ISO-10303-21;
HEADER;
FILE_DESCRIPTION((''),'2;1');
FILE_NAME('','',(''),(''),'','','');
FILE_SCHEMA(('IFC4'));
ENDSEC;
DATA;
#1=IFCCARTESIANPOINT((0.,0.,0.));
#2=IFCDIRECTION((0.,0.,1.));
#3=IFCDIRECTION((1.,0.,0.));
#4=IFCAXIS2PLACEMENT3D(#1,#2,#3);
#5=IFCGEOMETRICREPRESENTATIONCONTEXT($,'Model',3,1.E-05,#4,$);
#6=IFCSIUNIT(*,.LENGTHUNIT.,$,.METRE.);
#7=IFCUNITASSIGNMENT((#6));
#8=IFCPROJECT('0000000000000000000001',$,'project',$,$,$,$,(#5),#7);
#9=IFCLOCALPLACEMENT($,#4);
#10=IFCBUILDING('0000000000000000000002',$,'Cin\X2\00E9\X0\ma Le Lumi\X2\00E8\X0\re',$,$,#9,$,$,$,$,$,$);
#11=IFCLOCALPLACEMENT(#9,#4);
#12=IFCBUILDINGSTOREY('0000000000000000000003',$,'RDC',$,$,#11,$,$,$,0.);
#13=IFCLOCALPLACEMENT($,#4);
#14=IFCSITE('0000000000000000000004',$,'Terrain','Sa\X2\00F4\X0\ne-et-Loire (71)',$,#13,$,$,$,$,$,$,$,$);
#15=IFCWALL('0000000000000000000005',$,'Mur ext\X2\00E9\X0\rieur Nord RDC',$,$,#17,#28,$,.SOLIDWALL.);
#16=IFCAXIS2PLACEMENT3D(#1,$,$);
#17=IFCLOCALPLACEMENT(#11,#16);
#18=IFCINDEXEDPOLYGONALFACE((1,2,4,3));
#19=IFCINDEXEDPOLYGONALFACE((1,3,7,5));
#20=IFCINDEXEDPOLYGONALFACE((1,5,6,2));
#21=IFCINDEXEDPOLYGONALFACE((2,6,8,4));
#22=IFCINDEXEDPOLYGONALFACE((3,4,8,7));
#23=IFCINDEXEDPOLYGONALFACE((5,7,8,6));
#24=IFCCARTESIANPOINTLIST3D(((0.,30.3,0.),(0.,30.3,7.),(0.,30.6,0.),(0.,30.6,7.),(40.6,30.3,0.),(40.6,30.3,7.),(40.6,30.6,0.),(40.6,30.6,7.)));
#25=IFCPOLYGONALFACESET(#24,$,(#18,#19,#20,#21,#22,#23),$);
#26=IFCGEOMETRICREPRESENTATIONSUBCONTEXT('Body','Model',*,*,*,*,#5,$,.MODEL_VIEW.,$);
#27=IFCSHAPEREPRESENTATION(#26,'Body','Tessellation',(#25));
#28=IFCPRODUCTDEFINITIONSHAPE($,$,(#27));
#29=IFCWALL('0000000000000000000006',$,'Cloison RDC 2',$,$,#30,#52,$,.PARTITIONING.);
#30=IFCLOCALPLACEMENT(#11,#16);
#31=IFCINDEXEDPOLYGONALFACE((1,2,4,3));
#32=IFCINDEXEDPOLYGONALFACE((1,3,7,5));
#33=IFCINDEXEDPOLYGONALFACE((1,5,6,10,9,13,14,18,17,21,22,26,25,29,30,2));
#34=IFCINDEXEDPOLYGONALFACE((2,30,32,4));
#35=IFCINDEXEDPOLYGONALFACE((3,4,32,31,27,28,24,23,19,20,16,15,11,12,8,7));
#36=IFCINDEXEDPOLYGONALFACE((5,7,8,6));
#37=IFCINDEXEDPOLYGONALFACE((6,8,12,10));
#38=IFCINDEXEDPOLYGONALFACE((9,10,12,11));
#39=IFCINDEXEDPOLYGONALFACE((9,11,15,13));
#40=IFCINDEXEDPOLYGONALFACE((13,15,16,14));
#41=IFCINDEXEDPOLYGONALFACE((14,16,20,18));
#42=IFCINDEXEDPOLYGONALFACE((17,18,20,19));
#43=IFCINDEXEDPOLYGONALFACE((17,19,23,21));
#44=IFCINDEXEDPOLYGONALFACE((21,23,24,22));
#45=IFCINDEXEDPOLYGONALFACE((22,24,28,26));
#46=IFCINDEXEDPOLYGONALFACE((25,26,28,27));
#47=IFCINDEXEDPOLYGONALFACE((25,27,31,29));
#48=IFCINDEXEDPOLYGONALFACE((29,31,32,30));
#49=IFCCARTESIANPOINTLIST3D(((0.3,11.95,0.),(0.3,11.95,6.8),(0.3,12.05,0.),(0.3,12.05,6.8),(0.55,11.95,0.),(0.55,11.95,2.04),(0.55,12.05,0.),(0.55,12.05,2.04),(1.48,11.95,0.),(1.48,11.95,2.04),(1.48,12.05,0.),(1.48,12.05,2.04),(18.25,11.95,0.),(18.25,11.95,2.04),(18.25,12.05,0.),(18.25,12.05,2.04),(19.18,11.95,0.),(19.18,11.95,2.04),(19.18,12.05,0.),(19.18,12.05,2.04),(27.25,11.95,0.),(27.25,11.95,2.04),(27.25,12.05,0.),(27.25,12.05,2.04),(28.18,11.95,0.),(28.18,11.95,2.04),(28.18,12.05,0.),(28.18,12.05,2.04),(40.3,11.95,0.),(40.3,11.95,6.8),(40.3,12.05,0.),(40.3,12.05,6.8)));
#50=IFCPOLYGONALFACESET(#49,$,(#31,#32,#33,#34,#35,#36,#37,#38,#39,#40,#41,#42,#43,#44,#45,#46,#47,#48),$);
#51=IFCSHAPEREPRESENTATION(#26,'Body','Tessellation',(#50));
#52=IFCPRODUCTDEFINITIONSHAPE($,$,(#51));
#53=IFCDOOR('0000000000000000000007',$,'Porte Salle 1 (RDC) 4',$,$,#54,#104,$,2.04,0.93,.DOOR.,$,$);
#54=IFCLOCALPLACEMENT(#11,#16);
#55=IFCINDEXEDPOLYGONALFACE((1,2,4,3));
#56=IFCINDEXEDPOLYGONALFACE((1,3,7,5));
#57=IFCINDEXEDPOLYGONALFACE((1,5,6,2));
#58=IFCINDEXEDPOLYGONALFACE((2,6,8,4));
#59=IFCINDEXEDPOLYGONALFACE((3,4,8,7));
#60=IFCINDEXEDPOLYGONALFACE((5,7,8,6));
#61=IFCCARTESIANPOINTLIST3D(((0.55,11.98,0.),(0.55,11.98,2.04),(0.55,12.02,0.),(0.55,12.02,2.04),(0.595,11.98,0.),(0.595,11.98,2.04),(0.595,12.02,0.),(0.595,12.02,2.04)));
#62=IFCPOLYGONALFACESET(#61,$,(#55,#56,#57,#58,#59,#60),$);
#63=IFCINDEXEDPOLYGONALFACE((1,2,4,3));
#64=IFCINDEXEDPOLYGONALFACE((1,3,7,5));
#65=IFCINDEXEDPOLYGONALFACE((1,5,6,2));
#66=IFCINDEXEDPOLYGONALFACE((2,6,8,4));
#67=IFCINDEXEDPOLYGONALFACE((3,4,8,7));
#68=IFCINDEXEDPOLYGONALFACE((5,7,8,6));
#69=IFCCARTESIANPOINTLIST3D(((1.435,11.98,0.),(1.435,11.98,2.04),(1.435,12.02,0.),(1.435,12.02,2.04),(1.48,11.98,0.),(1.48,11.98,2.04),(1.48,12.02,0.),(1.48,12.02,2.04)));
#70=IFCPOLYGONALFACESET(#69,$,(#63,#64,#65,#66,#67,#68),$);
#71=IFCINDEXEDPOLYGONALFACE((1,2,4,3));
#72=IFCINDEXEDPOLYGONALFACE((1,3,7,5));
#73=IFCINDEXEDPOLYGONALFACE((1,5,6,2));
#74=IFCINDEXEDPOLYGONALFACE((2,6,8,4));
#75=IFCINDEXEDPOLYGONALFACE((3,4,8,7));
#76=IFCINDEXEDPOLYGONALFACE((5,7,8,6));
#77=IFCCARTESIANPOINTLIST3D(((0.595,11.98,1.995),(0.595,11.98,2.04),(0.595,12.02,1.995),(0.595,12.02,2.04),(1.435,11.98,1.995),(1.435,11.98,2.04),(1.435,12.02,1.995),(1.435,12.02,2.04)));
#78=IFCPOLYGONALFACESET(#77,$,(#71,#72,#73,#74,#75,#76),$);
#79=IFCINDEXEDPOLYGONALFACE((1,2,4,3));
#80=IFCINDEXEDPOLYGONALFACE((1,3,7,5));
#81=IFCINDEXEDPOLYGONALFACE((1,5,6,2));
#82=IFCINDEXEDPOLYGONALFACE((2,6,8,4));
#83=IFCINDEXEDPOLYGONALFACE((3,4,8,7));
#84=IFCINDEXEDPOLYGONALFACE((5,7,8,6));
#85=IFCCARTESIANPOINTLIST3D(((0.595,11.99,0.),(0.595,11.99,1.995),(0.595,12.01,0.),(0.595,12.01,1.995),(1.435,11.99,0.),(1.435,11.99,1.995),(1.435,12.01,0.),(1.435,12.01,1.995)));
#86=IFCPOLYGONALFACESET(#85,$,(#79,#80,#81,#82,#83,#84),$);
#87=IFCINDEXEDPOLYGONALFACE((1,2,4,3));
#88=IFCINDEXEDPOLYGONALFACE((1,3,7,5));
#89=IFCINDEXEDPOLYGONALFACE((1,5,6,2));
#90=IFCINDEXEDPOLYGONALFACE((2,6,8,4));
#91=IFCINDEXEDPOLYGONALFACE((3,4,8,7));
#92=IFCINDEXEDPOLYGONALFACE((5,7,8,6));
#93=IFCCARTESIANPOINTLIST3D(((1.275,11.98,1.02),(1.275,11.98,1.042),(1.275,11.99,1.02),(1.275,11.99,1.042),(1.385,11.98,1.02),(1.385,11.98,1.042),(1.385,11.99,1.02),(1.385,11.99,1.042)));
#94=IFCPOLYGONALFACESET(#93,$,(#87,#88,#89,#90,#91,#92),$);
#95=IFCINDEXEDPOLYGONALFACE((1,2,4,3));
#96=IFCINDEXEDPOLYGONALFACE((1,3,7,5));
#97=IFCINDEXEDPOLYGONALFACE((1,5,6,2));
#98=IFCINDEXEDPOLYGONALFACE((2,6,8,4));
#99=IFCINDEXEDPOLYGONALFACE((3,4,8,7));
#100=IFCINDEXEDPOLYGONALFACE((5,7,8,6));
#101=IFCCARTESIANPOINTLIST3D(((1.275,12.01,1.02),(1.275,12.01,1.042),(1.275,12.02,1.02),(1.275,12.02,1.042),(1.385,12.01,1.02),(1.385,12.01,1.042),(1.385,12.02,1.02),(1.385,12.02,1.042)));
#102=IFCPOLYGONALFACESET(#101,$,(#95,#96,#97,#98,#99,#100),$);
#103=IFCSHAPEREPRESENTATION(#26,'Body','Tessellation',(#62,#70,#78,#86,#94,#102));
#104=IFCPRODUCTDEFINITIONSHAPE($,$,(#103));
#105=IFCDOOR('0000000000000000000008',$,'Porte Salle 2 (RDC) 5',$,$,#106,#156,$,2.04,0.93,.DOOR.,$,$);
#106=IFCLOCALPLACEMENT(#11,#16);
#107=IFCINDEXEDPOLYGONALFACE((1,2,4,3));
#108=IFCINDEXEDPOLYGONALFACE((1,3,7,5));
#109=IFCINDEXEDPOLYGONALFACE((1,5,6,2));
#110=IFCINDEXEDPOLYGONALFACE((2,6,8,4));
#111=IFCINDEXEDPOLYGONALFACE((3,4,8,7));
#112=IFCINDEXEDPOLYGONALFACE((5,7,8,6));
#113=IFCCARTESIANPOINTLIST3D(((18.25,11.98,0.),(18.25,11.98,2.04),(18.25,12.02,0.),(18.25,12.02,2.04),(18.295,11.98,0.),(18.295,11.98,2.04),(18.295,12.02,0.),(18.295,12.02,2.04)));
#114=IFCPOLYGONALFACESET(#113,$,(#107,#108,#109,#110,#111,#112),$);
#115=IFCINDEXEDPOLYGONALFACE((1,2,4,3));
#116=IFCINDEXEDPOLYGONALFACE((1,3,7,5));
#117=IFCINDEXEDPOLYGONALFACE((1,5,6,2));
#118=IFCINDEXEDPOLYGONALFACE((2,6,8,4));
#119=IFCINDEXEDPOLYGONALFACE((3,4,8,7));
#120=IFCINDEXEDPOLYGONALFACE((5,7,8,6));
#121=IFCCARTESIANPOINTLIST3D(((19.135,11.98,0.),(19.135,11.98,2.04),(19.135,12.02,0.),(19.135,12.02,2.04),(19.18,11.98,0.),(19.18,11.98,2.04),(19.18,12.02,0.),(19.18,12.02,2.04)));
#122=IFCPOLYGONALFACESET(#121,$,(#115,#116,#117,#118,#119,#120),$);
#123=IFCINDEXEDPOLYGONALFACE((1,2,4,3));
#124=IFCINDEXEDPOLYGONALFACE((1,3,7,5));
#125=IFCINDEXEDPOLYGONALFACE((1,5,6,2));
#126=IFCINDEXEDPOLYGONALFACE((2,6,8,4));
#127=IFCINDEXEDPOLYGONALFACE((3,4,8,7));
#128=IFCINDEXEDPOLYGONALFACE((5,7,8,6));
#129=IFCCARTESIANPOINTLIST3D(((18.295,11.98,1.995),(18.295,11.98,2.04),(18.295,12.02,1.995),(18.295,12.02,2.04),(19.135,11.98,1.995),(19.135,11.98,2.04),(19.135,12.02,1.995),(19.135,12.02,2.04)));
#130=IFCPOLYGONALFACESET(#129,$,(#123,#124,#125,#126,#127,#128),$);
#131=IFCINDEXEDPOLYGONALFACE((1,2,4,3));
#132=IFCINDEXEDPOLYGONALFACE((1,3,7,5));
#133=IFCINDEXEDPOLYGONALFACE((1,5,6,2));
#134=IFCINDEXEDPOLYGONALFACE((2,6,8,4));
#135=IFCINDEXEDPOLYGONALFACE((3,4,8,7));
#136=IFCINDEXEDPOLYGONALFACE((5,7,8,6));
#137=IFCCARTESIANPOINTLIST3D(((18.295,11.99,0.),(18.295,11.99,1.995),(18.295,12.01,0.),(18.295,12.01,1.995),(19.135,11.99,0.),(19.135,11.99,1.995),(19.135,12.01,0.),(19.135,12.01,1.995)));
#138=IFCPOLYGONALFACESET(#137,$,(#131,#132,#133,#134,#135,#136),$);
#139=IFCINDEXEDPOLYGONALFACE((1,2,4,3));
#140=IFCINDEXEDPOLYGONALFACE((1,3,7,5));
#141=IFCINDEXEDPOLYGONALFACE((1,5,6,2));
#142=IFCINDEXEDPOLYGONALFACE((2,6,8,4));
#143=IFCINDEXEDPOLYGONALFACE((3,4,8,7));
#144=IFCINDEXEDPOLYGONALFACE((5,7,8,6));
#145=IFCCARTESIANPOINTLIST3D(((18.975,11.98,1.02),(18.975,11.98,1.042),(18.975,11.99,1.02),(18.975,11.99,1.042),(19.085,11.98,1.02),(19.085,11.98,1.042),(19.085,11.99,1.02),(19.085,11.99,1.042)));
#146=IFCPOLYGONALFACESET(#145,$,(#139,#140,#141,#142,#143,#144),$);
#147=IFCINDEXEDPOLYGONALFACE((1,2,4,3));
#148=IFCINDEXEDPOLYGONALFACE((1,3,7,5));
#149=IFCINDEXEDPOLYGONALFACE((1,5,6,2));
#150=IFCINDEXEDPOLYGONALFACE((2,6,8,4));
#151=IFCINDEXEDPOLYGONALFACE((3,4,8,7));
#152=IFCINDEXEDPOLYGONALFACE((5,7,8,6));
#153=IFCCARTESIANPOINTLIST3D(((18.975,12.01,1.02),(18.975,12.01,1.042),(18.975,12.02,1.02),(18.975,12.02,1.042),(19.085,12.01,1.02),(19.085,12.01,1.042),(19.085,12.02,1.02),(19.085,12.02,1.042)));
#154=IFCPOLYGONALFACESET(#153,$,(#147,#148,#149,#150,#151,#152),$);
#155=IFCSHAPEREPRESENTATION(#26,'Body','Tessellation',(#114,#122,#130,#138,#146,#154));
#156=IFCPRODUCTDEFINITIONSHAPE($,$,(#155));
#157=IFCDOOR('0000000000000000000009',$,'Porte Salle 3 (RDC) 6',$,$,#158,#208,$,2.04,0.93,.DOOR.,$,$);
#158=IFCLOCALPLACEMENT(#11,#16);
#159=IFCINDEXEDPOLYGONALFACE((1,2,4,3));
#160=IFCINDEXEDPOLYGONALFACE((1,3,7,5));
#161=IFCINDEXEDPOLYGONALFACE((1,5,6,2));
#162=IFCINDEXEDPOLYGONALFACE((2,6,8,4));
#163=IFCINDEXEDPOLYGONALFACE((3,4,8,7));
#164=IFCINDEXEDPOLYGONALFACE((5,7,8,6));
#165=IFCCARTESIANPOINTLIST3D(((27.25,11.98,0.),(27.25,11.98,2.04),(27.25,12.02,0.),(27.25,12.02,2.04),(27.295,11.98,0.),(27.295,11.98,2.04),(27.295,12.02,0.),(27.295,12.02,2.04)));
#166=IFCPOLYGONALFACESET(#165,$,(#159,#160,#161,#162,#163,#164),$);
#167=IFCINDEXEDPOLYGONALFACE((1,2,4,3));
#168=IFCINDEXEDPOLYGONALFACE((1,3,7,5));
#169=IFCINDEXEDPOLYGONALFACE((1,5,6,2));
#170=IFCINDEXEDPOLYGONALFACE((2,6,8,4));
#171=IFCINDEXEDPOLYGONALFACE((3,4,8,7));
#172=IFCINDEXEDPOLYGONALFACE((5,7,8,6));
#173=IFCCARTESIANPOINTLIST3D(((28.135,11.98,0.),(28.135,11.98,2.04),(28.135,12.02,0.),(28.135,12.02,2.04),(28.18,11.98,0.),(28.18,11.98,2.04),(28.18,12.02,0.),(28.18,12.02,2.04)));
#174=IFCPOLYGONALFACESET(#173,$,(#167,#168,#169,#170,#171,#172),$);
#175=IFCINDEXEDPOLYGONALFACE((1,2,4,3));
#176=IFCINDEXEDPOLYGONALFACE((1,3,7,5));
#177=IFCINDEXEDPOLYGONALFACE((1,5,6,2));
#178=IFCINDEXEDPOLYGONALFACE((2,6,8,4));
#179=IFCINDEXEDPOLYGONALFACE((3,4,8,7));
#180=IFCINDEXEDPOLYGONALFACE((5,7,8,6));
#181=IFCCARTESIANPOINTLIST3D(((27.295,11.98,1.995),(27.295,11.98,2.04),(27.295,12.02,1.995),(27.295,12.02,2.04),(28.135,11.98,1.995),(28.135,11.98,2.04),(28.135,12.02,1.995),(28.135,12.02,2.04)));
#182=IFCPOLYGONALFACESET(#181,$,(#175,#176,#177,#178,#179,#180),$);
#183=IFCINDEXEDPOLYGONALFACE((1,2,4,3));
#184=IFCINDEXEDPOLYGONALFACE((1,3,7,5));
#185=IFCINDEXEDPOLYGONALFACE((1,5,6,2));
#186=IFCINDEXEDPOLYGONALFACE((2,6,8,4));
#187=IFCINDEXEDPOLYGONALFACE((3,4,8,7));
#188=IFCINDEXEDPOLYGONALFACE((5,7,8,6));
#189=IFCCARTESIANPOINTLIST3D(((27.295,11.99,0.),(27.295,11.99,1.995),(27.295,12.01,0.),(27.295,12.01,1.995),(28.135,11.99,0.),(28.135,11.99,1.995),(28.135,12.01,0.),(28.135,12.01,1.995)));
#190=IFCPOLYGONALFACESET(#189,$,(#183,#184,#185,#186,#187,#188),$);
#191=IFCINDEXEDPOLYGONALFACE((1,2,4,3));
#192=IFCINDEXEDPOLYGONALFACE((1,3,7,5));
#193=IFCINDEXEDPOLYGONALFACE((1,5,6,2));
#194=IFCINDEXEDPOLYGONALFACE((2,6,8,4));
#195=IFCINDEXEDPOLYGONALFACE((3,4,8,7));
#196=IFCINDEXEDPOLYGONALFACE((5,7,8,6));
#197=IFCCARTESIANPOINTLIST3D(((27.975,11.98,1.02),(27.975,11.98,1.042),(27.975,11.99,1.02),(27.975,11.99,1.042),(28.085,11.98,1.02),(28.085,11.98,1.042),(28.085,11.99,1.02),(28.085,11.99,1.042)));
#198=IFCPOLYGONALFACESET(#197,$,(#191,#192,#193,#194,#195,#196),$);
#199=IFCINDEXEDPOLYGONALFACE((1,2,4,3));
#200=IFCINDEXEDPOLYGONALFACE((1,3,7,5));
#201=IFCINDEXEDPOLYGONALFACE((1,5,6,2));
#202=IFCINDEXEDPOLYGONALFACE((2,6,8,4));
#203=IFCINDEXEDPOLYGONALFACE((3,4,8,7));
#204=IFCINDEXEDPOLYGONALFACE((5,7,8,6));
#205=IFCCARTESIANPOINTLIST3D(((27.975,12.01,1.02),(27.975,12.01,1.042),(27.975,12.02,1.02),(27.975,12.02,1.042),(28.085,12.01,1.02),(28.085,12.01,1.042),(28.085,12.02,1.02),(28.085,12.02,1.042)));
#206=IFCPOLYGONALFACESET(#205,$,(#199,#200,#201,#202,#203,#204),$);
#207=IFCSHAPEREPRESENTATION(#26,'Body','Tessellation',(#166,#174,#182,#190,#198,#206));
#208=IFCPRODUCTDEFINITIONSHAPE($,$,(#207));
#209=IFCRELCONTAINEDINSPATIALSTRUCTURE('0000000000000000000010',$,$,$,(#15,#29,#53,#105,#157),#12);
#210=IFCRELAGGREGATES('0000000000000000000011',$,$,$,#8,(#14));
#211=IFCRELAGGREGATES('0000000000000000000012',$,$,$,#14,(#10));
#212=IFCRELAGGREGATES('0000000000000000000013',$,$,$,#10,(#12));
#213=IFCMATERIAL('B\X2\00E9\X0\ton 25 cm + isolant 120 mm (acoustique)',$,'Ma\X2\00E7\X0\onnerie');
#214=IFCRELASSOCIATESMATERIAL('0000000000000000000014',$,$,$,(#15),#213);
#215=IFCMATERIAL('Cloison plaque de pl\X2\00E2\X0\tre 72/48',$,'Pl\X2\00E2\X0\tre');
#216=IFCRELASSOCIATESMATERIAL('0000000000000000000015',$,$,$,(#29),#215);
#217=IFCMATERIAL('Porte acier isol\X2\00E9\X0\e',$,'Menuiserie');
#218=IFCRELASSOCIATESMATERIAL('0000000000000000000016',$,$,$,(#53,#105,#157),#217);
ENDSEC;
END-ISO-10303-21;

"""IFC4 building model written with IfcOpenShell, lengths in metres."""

from ifc_helpers import new_model, si_unit, frame, frame_2d, origin_with_axes, place, context, subcontext, project, spatial, rectangle, extrude, material, element, fill, save


model = new_model("IFC4")

# Units and contexts
model_context = context("Model", 3, precision=1e-05, world=origin_with_axes())
body_context = subcontext(model_context, "Body", "Model", "MODEL_VIEW")
ifc_project = project(units=[si_unit("LENGTHUNIT", "METRE")], contexts=[model_context])

# Site, building, storey
site_placement = place(None, origin_with_axes())
site = spatial("IfcSite", under=ifc_project, at=site_placement, Name="Terrain", Description="Saône-et-Loire (71)")
building_placement = place(None, origin_with_axes())
building = spatial("IfcBuilding", under=site, at=building_placement, Name="Cinéma Le Lumière")
storey_placement = place(building_placement, origin_with_axes())
storey = spatial("IfcBuildingStorey", under=building, at=storey_placement, Name="RDC", Elevation=0.0)

# Wall
ifc_material_1 = material(Name="Béton 25 cm + isolant 120 mm (acoustique)", Category="Maçonnerie")
wall_1_placement = place(storey_placement, frame((0.0, 30.3, 0.0), z_axis=(0.0, 0.0, 1.0), x_axis=(1.0, 0.0, 0.0)))
element("IfcWall", 1, at=wall_1_placement, inside=storey, material=ifc_material_1, Name="Mur extérieur Nord RDC", PredefinedType="SOLIDWALL", context=body_context, shape_type="SweptSolid", body=[
    extrude(rectangle(XDim=40.6, YDim=0.3, at=frame_2d((20.3, 0.15))), origin_with_axes(), (0.0, 0.0, 1.0), 7.0),
])

# Wall, openings, doors
ifc_material_2 = material(Name="Cloison plaque de plâtre 72/48", Category="Plâtre")
wall_2_placement = place(storey_placement, frame((0.3, 11.95, 0.0), z_axis=(0.0, 0.0, 1.0), x_axis=(1.0, 0.0, 0.0)))
wall_2 = element("IfcWall", 2, at=wall_2_placement, inside=storey, material=ifc_material_2, Name="Cloison RDC 2", PredefinedType="PARTITIONING", context=body_context, shape_type="SweptSolid", body=[
    extrude(rectangle(XDim=40.0, YDim=0.1, at=frame_2d((20.0, 0.05))), origin_with_axes(), (0.0, 0.0, 1.0), 6.8),
])
opening_1_placement = place(storey_placement, frame((0.55, 11.9, 0.0), z_axis=(0.0, 0.0, 1.0), x_axis=(1.0, 0.0, 0.0)))
opening_1 = element("IfcOpeningElement", 3, at=opening_1_placement, cuts=wall_2, context=body_context, shape_type="SweptSolid", body=[
    extrude(rectangle(XDim=0.93, YDim=0.2, at=frame_2d((0.465, 0.1))), origin_with_axes(), (0.0, 0.0, 1.0), 2.04),
])
opening_2_placement = place(storey_placement, frame((18.25, 11.9, 0.0), z_axis=(0.0, 0.0, 1.0), x_axis=(1.0, 0.0, 0.0)))
opening_2 = element("IfcOpeningElement", 4, at=opening_2_placement, cuts=wall_2, context=body_context, shape_type="SweptSolid", body=[
    extrude(rectangle(XDim=0.93, YDim=0.2, at=frame_2d((0.465, 0.1))), origin_with_axes(), (0.0, 0.0, 1.0), 2.04),
])
opening_3_placement = place(storey_placement, frame((27.25, 11.9, 0.0), z_axis=(0.0, 0.0, 1.0), x_axis=(1.0, 0.0, 0.0)))
opening_3 = element("IfcOpeningElement", 5, at=opening_3_placement, cuts=wall_2, context=body_context, shape_type="SweptSolid", body=[
    extrude(rectangle(XDim=0.93, YDim=0.2, at=frame_2d((0.465, 0.1))), origin_with_axes(), (0.0, 0.0, 1.0), 2.04),
])
ifc_material_3 = material(Name="Porte acier isolée", Category="Menuiserie")
door_1_placement = place(storey_placement, frame((0.55, 11.98, 0.0), z_axis=(0.0, 0.0, 1.0), x_axis=(1.0, 0.0, 0.0)))
door_1 = element("IfcDoor", 6, at=door_1_placement, inside=storey, material=ifc_material_3, Name="Porte Salle 1 (RDC) 4", OverallHeight=2.04, OverallWidth=0.93, PredefinedType="DOOR", context=body_context, shape_type="SweptSolid", body=[
    extrude(rectangle(XDim=0.045, YDim=0.04, at=frame_2d((0.0225, 0.02))), origin_with_axes(), (0.0, 0.0, 1.0), 2.04),
    extrude(rectangle(XDim=0.045, YDim=0.04, at=frame_2d((0.0225, 0.02))), frame((0.885, 0.0, 0.0), z_axis=(0.0, 0.0, 1.0), x_axis=(1.0, 0.0, 0.0)), (0.0, 0.0, 1.0), 2.04),
    extrude(rectangle(XDim=0.84, YDim=0.04, at=frame_2d((0.42, 0.02))), frame((0.045, 0.0, 1.995), z_axis=(0.0, 0.0, 1.0), x_axis=(1.0, 0.0, 0.0)), (0.0, 0.0, 1.0), 0.045),
    extrude(rectangle(XDim=0.84, YDim=0.02, at=frame_2d((0.42, 0.01))), frame((0.045, 0.01, 0.0), z_axis=(0.0, 0.0, 1.0), x_axis=(1.0, 0.0, 0.0)), (0.0, 0.0, 1.0), 1.995),
    extrude(rectangle(XDim=0.11, YDim=0.01, at=frame_2d((0.055, 0.005))), frame((0.725, 0.0, 1.02), z_axis=(0.0, 0.0, 1.0), x_axis=(1.0, 0.0, 0.0)), (0.0, 0.0, 1.0), 0.022),
    extrude(rectangle(XDim=0.11, YDim=0.01, at=frame_2d((0.055, 0.005))), frame((0.725, 0.03, 1.02), z_axis=(0.0, 0.0, 1.0), x_axis=(1.0, 0.0, 0.0)), (0.0, 0.0, 1.0), 0.022),
])
fill(opening_1, door_1)
door_2_placement = place(storey_placement, frame((18.25, 11.98, 0.0), z_axis=(0.0, 0.0, 1.0), x_axis=(1.0, 0.0, 0.0)))
door_2 = element("IfcDoor", 7, at=door_2_placement, inside=storey, material=ifc_material_3, Name="Porte Salle 2 (RDC) 5", OverallHeight=2.04, OverallWidth=0.93, PredefinedType="DOOR", context=body_context, shape_type="SweptSolid", body=[
    extrude(rectangle(XDim=0.045, YDim=0.04, at=frame_2d((0.0225, 0.02))), origin_with_axes(), (0.0, 0.0, 1.0), 2.04),
    extrude(rectangle(XDim=0.045, YDim=0.04, at=frame_2d((0.0225, 0.02))), frame((0.885, 0.0, 0.0), z_axis=(0.0, 0.0, 1.0), x_axis=(1.0, 0.0, 0.0)), (0.0, 0.0, 1.0), 2.04),
    extrude(rectangle(XDim=0.84, YDim=0.04, at=frame_2d((0.42, 0.02))), frame((0.045, 0.0, 1.995), z_axis=(0.0, 0.0, 1.0), x_axis=(1.0, 0.0, 0.0)), (0.0, 0.0, 1.0), 0.045),
    extrude(rectangle(XDim=0.84, YDim=0.02, at=frame_2d((0.42, 0.01))), frame((0.045, 0.01, 0.0), z_axis=(0.0, 0.0, 1.0), x_axis=(1.0, 0.0, 0.0)), (0.0, 0.0, 1.0), 1.995),
    extrude(rectangle(XDim=0.11, YDim=0.01, at=frame_2d((0.055, 0.005))), frame((0.725, 0.0, 1.02), z_axis=(0.0, 0.0, 1.0), x_axis=(1.0, 0.0, 0.0)), (0.0, 0.0, 1.0), 0.022),
    extrude(rectangle(XDim=0.11, YDim=0.01, at=frame_2d((0.055, 0.005))), frame((0.725, 0.03, 1.02), z_axis=(0.0, 0.0, 1.0), x_axis=(1.0, 0.0, 0.0)), (0.0, 0.0, 1.0), 0.022),
])
fill(opening_2, door_2)
door_3_placement = place(storey_placement, frame((27.25, 11.98, 0.0), z_axis=(0.0, 0.0, 1.0), x_axis=(1.0, 0.0, 0.0)))
door_3 = element("IfcDoor", 8, at=door_3_placement, inside=storey, material=ifc_material_3, Name="Porte Salle 3 (RDC) 6", OverallHeight=2.04, OverallWidth=0.93, PredefinedType="DOOR", context=body_context, shape_type="SweptSolid", body=[
    extrude(rectangle(XDim=0.045, YDim=0.04, at=frame_2d((0.0225, 0.02))), origin_with_axes(), (0.0, 0.0, 1.0), 2.04),
    extrude(rectangle(XDim=0.045, YDim=0.04, at=frame_2d((0.0225, 0.02))), frame((0.885, 0.0, 0.0), z_axis=(0.0, 0.0, 1.0), x_axis=(1.0, 0.0, 0.0)), (0.0, 0.0, 1.0), 2.04),
    extrude(rectangle(XDim=0.84, YDim=0.04, at=frame_2d((0.42, 0.02))), frame((0.045, 0.0, 1.995), z_axis=(0.0, 0.0, 1.0), x_axis=(1.0, 0.0, 0.0)), (0.0, 0.0, 1.0), 0.045),
    extrude(rectangle(XDim=0.84, YDim=0.02, at=frame_2d((0.42, 0.01))), frame((0.045, 0.01, 0.0), z_axis=(0.0, 0.0, 1.0), x_axis=(1.0, 0.0, 0.0)), (0.0, 0.0, 1.0), 1.995),
    extrude(rectangle(XDim=0.11, YDim=0.01, at=frame_2d((0.055, 0.005))), frame((0.725, 0.0, 1.02), z_axis=(0.0, 0.0, 1.0), x_axis=(1.0, 0.0, 0.0)), (0.0, 0.0, 1.0), 0.022),
    extrude(rectangle(XDim=0.11, YDim=0.01, at=frame_2d((0.055, 0.005))), frame((0.725, 0.03, 1.02), z_axis=(0.0, 0.0, 1.0), x_axis=(1.0, 0.0, 0.0)), (0.0, 0.0, 1.0), 0.022),
])
fill(opening_3, door_3)

save(model, "model.ifc")
